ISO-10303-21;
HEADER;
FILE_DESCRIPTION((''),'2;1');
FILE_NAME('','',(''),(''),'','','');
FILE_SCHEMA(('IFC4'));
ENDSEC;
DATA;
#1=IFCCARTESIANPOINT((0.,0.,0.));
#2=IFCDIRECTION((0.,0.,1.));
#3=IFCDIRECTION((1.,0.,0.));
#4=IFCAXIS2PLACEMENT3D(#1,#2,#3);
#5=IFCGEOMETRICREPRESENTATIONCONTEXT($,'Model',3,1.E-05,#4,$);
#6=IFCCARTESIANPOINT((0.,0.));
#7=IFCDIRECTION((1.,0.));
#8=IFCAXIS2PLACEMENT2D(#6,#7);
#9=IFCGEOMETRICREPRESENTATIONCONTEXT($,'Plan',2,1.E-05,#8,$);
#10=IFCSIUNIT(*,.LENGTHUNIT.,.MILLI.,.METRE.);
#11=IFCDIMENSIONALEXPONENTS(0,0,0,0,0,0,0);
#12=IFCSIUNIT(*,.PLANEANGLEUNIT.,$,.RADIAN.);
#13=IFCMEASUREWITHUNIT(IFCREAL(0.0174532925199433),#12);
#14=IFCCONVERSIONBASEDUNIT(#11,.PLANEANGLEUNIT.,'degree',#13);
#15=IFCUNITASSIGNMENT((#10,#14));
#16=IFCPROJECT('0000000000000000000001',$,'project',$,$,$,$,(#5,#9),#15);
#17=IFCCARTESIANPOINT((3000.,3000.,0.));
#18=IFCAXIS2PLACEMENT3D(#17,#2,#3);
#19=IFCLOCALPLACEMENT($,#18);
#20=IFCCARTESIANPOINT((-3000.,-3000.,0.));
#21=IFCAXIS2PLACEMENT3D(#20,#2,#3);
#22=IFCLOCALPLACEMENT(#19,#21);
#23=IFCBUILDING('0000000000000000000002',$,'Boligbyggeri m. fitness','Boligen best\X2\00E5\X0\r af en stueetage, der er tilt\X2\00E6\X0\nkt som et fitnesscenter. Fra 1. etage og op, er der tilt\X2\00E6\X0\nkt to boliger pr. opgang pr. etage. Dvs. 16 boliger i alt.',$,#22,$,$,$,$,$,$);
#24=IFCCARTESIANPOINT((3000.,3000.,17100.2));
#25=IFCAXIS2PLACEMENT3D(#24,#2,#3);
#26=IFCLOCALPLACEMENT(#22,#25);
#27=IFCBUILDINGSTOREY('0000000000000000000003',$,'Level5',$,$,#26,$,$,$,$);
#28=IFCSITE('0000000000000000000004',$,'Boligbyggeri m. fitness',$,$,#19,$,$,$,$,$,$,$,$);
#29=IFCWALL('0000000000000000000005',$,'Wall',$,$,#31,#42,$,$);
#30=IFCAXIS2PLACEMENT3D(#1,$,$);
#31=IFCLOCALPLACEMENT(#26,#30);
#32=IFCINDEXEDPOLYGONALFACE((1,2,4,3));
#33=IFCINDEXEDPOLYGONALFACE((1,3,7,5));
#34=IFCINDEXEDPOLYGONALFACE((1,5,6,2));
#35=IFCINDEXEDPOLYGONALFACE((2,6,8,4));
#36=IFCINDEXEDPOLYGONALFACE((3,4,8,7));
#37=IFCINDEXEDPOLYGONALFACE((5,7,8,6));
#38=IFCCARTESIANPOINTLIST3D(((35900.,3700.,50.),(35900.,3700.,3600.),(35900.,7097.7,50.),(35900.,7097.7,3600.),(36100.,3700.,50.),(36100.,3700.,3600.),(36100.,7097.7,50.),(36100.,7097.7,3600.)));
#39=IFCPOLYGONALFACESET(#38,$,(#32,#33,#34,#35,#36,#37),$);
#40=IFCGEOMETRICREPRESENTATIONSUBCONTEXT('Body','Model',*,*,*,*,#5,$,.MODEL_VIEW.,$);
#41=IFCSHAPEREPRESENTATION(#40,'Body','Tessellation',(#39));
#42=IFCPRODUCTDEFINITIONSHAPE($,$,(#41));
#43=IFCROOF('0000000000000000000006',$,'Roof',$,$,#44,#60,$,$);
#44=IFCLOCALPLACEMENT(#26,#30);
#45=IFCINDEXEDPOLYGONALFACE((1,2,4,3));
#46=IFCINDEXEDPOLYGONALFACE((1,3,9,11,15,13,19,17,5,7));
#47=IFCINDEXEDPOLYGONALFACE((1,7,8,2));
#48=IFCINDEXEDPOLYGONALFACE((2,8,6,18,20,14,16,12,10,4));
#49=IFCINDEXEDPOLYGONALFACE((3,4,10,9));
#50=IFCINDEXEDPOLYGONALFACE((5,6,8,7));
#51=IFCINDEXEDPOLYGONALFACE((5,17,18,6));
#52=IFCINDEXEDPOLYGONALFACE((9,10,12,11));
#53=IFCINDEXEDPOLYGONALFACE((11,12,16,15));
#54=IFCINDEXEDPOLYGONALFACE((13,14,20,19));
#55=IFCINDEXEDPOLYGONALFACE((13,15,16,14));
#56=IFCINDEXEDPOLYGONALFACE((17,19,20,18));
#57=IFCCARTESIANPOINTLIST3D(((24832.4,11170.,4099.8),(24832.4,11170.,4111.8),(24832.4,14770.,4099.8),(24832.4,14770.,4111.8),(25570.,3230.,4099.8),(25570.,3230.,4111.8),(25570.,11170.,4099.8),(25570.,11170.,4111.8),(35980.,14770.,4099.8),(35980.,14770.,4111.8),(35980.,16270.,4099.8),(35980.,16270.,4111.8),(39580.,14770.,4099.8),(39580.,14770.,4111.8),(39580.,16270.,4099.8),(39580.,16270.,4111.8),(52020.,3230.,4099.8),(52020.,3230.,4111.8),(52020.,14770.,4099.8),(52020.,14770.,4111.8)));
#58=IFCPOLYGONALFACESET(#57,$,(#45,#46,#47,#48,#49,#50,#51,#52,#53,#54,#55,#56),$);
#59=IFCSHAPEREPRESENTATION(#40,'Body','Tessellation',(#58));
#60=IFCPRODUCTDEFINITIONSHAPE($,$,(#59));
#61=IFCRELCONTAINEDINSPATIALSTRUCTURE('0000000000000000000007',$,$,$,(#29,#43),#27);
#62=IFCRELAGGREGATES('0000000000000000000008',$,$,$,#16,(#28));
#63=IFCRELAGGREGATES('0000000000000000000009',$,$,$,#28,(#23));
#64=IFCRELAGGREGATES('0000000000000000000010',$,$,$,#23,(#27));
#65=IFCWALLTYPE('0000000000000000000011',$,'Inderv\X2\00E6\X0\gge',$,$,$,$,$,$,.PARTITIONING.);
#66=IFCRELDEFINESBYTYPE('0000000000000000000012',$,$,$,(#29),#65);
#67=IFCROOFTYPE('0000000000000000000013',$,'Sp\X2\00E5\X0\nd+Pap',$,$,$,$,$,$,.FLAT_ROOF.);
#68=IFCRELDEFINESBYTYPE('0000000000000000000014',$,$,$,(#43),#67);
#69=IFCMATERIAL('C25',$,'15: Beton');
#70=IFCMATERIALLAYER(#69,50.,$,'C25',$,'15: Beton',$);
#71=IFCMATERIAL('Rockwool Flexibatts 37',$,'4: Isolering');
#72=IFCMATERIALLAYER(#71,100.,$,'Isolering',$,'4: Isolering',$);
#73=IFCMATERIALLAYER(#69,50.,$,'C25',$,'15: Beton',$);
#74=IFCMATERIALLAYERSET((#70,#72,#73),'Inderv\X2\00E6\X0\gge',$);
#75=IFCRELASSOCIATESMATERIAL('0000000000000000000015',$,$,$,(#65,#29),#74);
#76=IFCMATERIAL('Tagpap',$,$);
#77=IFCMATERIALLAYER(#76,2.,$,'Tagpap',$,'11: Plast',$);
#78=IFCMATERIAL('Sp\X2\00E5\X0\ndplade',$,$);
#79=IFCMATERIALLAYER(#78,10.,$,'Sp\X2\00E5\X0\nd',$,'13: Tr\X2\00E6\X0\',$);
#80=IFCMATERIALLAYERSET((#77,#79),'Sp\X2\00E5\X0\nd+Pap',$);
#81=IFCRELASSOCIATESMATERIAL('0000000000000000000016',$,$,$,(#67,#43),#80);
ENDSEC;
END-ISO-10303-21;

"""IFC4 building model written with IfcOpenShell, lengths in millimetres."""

from ifc_helpers import new_model, entity, si_unit, converted_unit, frame, origin_with_axes, origin_2d_with_axis, place, context, subcontext, project, spatial, line, indexed_curve, outline, extrude, material, layer, layer_set, layer_usage, type_object, element, save


model = new_model("IFC4")

# Units and contexts
model_context = context("Model", 3, precision=1e-05, world=origin_with_axes())
plan_context = context("Plan", 2, precision=1e-05, world=origin_2d_with_axis())
body_context = subcontext(model_context, "Body", "Model", "MODEL_VIEW")
ifc_project = project(units=[si_unit("LENGTHUNIT", "METRE", prefix="MILLI"), converted_unit("PLANEANGLEUNIT", "degree", entity("IfcReal", 0.0174532925199433), si_unit("PLANEANGLEUNIT", "RADIAN"), dimensions=[0, 0, 0, 0, 0, 0, 0])], contexts=[model_context, plan_context])

# Site, building, storey
site_placement = place(None, frame((3000.0, 3000.0, 0.0), z_axis=(0.0, 0.0, 1.0), x_axis=(1.0, 0.0, 0.0)))
site = spatial("IfcSite", under=ifc_project, at=site_placement, Name="Boligbyggeri m. fitness")
building_placement = place(site_placement, frame((-3000.0, -3000.0, 0.0), z_axis=(0.0, 0.0, 1.0), x_axis=(1.0, 0.0, 0.0)))
building = spatial("IfcBuilding", under=site, at=building_placement, Name="Boligbyggeri m. fitness", Description="Boligen består af en stueetage, der er tiltænkt som et fitnesscenter. Fra 1. etage og op, er der tiltænkt to boliger pr. opgang pr. etage. Dvs. 16 boliger i alt.")
storey_placement = place(building_placement, frame((3000.0, 3000.0, 17100.2), z_axis=(0.0, 0.0, 1.0), x_axis=(1.0, 0.0, 0.0)))
storey = spatial("IfcBuildingStorey", under=building, at=storey_placement, Name="Level5")

# Shared definitions
ifc_material_1 = material(Name="C25", Category="15: Beton")

# Wall
ifc_layer_1 = layer(ifc_material_1, 50.0, Name="C25", Category="15: Beton")
ifc_material_2 = material(Name="Rockwool Flexibatts 37", Category="4: Isolering")
ifc_layer_2 = layer(ifc_material_2, 100.0, Name="Isolering", Category="4: Isolering")
ifc_layer_3 = layer(ifc_material_1, 50.0, Name="C25", Category="15: Beton")
ifc_layer_set_1 = layer_set([ifc_layer_1, ifc_layer_2, ifc_layer_3], Name="Indervægge")
ifc_layer_usage_1 = layer_usage(ifc_layer_set_1, "AXIS2", "POSITIVE", 0.0)
wall_type = type_object("IfcWallType", Name="Indervægge", PredefinedType="PARTITIONING", material=ifc_layer_set_1)
wall_placement = place(storey_placement, frame((35900.0, 7097.7, 50.0), z_axis=(0.0, 0.0, 1.0), x_axis=(-0.000001, -1.0, 0.0)))
element("IfcWall", 1, at=wall_placement, inside=storey, type_object=wall_type, material=ifc_layer_usage_1, Name="Wall", context=body_context, shape_type="SweptSolid", body=[
    extrude(outline(indexed_curve([(0.0, 0.0), (0.0, 200.0), (3397.7, 200.0), (3397.7, 0.0), (0.0, 0.0)], self_intersect=False)), origin_with_axes(), (0.0, 0.0, 1.0), 3550.0),
])

# Roof
ifc_material_3 = material(Name="Tagpap")
ifc_layer_4 = layer(ifc_material_3, 2.0, Name="Tagpap", Category="11: Plast")
ifc_material_4 = material(Name="Spåndplade")
ifc_layer_5 = layer(ifc_material_4, 10.0, Name="Spånd", Category="13: Træ")
ifc_layer_set_2 = layer_set([ifc_layer_4, ifc_layer_5], Name="Spånd+Pap")
ifc_layer_usage_2 = layer_usage(ifc_layer_set_2, "AXIS3", "POSITIVE", 0.0)
roof_type_1 = type_object("IfcRoofType", Name="Spånd+Pap", PredefinedType="FLAT_ROOF", material=ifc_layer_set_2)
roof_1_placement = place(storey_placement, frame((25570.0, 3230.0, 4099.8), z_axis=(0.0, 0.0, 1.0), x_axis=(1.0, 0.0, 0.0)))
element("IfcRoof", 2, at=roof_1_placement, inside=storey, type_object=roof_type_1, material=ifc_layer_usage_2, Name="Roof", context=body_context, shape_type="SweptSolid", body=[
    extrude(outline(indexed_curve([(26450.0, 0.0), (26450.0, 11540.0), (-737.6, 11540.0), (-737.6, 7940.0), (0.0, 7940.0), (0.0, 0.0), (14010.0, 11540.0), (10410.0, 11540.0), (10410.0, 13040.0), (14010.0, 13040.0)], segments=[line(8, 3), line(3, 4), line(4, 5), line(5, 6), line(6, 1), line(1, 2), line(2, 7), line(7, 10), line(10, 9), line(9, 8)], self_intersect=False)), None, (0.0, 0.0, 1.0), 12.0),
])

save(model, "model.ifc")
